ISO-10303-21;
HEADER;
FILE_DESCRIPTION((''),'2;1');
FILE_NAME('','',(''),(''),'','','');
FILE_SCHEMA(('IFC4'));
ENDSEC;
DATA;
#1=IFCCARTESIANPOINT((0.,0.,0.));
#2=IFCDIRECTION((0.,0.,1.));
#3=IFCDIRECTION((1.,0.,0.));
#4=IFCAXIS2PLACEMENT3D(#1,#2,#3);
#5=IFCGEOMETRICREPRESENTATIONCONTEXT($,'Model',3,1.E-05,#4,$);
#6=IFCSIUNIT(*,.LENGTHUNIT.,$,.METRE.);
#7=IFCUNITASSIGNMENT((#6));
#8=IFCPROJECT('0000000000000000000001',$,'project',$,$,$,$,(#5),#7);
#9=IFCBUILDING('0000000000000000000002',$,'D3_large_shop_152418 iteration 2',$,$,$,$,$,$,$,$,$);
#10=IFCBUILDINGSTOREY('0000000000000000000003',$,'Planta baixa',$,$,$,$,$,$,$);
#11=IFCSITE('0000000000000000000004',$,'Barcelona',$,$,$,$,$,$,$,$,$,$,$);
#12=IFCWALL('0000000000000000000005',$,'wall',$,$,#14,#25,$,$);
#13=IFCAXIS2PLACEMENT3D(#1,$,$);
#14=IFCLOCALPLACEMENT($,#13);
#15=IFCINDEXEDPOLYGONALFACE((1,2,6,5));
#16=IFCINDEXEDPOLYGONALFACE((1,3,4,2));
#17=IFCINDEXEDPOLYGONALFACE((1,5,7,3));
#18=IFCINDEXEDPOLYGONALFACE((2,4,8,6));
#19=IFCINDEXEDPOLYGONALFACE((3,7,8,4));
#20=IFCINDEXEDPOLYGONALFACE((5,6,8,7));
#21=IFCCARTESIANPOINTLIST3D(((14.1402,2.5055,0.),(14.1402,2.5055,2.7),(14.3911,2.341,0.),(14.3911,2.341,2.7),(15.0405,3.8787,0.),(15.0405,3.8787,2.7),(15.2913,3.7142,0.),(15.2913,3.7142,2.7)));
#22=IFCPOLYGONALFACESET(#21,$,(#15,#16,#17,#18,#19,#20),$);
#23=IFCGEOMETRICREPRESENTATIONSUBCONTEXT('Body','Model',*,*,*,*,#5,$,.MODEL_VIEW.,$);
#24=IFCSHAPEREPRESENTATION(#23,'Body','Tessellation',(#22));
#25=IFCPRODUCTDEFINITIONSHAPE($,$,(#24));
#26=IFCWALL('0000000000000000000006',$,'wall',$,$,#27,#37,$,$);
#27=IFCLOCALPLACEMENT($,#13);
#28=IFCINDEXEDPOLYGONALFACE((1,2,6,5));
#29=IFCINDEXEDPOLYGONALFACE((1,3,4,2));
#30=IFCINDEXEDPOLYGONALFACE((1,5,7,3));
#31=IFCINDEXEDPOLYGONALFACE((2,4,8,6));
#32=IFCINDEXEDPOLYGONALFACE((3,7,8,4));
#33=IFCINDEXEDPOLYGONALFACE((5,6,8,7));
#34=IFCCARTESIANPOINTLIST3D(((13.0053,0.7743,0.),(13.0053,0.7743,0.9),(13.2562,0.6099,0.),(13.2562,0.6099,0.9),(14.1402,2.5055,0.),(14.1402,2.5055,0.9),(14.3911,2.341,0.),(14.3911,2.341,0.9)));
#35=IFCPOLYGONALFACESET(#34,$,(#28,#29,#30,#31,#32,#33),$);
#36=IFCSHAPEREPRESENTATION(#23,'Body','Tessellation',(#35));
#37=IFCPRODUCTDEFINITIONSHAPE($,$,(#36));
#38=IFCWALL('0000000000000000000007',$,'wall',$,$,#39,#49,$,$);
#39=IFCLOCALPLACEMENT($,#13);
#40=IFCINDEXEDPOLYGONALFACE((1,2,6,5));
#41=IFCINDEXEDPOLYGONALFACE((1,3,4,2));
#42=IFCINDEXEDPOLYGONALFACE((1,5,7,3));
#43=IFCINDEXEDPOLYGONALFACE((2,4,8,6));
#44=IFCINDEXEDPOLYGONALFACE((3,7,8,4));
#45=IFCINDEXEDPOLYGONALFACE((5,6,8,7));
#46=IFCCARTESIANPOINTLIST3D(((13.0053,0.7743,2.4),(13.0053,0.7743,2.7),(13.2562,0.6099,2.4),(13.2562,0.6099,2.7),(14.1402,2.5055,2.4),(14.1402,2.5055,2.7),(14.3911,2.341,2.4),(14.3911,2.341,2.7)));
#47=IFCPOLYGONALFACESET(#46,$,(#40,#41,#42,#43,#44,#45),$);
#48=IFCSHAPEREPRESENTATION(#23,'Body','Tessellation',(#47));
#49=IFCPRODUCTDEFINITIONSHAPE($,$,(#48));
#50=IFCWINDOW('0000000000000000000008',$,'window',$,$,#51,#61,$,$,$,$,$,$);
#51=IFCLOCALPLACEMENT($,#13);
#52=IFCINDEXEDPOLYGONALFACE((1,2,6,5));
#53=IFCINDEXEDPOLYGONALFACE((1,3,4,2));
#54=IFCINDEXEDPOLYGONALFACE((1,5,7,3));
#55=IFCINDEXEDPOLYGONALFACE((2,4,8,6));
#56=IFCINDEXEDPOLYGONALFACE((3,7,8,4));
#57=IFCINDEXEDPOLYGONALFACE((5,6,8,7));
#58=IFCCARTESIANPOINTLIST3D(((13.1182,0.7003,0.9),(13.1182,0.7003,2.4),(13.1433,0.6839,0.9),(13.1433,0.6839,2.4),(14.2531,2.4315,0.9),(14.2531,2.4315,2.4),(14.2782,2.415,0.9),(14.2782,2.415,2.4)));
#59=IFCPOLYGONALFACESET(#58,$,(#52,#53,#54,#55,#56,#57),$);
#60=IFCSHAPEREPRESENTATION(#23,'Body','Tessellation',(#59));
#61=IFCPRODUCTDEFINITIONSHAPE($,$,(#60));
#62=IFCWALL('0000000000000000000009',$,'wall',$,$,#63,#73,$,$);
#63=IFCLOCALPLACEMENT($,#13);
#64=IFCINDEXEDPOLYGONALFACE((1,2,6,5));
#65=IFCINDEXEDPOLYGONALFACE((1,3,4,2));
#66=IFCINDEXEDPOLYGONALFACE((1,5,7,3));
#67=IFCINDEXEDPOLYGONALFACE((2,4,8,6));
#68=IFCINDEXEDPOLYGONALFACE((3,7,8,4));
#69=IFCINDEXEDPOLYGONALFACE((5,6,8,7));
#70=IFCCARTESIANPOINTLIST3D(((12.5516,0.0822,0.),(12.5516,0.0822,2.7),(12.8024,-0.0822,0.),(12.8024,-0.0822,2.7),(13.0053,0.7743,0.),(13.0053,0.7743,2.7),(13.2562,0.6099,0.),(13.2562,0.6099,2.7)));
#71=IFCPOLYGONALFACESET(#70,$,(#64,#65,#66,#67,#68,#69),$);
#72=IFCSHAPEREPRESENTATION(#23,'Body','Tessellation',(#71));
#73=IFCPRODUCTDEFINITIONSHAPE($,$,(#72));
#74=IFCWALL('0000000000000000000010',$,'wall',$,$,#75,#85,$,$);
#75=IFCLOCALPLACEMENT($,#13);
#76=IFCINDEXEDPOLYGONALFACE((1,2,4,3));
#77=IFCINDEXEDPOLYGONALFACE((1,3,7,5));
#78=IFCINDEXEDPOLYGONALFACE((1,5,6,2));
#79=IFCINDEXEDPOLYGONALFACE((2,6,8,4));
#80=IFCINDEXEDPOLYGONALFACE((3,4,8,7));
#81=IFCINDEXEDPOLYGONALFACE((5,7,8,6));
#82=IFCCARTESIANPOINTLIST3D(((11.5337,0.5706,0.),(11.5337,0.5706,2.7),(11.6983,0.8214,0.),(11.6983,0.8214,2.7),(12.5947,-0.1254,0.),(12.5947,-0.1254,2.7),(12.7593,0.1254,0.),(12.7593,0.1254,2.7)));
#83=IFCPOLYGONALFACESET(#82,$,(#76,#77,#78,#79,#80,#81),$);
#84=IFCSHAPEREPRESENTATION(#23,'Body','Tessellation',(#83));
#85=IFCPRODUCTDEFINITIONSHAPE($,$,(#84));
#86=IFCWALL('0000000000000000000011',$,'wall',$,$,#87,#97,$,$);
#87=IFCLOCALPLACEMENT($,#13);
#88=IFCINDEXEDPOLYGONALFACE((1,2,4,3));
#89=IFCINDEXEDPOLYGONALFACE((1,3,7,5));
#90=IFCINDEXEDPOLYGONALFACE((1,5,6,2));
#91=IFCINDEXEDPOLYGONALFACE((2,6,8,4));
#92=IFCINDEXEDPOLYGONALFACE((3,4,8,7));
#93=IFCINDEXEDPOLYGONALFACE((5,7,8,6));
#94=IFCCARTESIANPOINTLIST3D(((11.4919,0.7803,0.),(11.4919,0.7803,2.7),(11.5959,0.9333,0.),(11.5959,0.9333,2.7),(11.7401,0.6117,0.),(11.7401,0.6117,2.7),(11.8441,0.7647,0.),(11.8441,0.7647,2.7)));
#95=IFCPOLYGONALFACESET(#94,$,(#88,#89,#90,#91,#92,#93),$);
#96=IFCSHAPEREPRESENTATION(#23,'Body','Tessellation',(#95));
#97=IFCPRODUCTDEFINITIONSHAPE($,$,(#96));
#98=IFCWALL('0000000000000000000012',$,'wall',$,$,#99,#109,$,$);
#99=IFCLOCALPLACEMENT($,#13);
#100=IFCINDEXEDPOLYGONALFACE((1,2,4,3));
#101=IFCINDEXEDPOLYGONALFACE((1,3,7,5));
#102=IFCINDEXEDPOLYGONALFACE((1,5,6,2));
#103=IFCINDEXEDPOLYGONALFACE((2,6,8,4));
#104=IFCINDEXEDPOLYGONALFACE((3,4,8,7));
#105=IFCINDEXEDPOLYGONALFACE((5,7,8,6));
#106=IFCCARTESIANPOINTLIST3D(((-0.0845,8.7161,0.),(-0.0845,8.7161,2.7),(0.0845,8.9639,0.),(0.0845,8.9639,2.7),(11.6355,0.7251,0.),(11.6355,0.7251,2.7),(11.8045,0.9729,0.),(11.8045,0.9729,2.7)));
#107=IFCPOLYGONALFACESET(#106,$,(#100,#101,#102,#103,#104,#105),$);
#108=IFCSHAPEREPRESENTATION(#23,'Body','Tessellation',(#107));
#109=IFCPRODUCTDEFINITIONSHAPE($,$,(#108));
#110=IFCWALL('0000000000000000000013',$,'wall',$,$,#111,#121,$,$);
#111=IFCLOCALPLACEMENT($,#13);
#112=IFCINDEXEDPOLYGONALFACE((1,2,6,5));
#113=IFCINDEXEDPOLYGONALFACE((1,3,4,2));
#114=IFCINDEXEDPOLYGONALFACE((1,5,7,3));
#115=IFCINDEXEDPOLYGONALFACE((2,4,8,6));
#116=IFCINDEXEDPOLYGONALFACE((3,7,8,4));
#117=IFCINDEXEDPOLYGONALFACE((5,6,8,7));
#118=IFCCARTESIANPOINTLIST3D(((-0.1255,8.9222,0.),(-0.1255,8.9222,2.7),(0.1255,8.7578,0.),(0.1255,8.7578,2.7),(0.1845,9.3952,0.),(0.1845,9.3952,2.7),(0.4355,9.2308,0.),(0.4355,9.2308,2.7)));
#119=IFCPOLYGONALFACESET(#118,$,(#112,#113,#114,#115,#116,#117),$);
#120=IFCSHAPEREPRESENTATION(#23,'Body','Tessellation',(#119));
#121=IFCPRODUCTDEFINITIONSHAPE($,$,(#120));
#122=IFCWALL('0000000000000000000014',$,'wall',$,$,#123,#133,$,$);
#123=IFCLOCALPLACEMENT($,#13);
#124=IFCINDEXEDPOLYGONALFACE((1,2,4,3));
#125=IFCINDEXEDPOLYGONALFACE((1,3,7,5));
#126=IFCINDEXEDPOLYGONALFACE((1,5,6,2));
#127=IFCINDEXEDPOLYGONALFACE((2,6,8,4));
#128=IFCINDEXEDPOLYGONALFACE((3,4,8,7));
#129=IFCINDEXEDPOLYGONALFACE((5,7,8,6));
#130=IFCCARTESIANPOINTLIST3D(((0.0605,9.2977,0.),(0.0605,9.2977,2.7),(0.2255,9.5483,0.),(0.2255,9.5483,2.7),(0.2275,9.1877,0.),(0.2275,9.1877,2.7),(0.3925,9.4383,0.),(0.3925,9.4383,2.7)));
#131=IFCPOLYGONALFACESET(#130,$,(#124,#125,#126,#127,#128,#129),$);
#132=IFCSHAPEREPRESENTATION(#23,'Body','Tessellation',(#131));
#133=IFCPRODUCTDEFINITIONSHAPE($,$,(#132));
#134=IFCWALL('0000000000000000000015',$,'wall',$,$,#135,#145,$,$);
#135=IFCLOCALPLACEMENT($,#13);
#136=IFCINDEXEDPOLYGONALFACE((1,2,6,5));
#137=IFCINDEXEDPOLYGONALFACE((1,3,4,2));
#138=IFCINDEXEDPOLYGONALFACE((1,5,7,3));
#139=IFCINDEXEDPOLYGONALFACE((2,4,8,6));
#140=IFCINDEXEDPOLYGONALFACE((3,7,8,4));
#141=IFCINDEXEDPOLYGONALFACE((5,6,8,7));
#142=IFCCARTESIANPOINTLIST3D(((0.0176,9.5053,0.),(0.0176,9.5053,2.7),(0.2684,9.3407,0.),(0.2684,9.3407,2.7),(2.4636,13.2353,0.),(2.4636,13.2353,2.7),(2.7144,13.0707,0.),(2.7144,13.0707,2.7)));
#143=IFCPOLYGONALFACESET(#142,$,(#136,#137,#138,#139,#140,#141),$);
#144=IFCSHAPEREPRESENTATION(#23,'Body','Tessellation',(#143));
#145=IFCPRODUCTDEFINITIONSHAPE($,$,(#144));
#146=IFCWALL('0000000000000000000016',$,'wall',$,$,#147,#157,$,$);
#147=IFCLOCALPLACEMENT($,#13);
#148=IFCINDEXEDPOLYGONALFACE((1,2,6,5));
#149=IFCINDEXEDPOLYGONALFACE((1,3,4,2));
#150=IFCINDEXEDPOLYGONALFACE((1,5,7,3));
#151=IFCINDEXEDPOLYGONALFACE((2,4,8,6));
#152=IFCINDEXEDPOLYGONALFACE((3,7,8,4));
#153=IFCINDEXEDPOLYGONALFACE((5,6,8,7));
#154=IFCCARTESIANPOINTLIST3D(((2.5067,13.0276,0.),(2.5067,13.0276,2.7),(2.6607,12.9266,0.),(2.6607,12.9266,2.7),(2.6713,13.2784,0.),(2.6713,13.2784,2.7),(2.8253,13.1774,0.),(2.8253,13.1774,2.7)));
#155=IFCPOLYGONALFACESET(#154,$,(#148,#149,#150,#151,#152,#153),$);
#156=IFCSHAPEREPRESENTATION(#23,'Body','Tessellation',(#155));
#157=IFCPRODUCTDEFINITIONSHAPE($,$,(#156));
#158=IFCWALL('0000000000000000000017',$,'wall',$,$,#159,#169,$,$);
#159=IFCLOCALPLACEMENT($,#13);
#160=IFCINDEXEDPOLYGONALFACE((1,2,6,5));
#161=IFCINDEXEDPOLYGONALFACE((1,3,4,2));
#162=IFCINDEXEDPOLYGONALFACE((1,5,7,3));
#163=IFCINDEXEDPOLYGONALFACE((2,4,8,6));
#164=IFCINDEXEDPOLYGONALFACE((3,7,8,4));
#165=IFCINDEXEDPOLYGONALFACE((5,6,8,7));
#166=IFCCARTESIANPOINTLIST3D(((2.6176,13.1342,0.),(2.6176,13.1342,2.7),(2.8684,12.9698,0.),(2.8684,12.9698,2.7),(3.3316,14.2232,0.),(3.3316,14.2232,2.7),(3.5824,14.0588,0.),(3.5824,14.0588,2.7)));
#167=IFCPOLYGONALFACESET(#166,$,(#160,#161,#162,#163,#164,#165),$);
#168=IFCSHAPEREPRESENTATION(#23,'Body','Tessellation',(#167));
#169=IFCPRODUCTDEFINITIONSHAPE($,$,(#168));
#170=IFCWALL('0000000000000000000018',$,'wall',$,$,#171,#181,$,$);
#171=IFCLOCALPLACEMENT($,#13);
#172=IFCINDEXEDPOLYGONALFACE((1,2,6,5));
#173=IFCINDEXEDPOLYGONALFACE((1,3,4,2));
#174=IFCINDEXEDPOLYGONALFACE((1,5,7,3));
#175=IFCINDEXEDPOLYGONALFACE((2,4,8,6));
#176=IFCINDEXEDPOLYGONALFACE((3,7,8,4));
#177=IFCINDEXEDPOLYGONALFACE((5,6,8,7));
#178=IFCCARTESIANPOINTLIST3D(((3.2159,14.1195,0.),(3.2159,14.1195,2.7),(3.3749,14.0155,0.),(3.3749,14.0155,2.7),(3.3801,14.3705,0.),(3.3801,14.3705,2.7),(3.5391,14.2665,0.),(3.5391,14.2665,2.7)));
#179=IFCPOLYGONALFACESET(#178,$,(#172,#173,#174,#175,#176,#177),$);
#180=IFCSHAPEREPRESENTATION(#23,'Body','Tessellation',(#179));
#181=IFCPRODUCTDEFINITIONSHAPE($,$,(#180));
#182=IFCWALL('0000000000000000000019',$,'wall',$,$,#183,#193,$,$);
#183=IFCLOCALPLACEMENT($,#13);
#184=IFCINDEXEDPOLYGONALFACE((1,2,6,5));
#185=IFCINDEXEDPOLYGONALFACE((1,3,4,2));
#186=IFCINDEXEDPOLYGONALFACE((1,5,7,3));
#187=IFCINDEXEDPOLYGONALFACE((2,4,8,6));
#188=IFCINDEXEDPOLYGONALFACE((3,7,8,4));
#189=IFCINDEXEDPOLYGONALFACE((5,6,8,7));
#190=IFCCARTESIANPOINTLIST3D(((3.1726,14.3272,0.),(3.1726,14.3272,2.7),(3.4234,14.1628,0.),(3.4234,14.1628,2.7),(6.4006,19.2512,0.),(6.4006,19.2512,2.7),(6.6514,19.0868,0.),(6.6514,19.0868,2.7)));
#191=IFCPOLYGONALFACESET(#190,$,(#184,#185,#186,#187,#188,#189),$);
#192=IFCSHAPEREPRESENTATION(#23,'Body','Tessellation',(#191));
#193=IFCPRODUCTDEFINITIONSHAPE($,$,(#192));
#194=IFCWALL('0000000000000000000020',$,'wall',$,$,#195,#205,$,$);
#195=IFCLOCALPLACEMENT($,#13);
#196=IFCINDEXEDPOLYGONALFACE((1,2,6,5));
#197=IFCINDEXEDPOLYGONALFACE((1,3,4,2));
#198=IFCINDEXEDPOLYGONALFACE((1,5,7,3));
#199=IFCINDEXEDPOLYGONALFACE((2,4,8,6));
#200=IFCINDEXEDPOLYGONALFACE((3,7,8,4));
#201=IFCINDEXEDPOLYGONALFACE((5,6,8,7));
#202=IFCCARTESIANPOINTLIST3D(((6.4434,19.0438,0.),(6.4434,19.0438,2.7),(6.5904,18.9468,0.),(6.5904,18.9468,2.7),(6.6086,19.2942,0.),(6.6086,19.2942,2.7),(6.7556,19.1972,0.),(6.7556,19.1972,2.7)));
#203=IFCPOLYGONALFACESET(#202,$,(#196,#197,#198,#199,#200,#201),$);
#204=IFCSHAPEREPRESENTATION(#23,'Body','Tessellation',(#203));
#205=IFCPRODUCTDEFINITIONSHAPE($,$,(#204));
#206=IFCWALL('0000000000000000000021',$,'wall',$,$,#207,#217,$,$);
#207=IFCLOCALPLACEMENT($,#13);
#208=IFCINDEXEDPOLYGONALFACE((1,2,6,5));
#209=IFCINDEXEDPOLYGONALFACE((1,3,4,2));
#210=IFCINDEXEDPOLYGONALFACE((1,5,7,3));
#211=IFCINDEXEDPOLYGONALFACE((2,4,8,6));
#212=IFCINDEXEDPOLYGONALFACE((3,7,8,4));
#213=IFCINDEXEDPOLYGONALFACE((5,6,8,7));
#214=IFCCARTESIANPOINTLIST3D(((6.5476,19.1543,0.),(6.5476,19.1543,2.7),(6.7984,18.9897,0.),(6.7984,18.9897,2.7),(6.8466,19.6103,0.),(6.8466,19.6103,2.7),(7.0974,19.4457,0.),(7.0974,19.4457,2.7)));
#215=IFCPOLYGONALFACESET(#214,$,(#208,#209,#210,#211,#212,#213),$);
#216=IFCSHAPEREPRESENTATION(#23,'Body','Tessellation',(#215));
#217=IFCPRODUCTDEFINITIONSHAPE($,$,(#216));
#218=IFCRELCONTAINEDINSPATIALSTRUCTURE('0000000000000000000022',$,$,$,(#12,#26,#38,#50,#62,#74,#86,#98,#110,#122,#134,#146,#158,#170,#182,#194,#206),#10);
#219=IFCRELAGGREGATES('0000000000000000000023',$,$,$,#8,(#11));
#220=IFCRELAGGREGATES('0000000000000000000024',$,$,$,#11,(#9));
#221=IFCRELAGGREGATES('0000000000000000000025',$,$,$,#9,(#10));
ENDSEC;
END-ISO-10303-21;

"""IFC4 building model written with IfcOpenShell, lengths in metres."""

from ifc_helpers import new_model, si_unit, frame, origin, origin_with_axes, place, context, subcontext, project, spatial, polyline, outline, extrude, element, save


model = new_model("IFC4")

# Units and contexts
model_context = context("Model", 3, precision=1e-05, world=origin_with_axes())
body_context = subcontext(model_context, "Body", "Model", "MODEL_VIEW")
ifc_project = project(units=[si_unit("LENGTHUNIT", "METRE")], contexts=[model_context])

# Site, building, storey
site = spatial("IfcSite", under=ifc_project, Name="Barcelona")
building = spatial("IfcBuilding", under=site, Name="D3_large_shop_152418 iteration 2")
storey = spatial("IfcBuildingStorey", under=building, Name="Planta baixa")

# Walls
wall_1_placement = place(None, origin_with_axes())
element("IfcWall", 1, at=wall_1_placement, inside=storey, Name="wall", context=body_context, shape_type="SweptSolid", body=[
    extrude(outline(polyline([(15.2913, 3.7142), (14.3911, 2.341), (14.1402, 2.5055), (15.0405, 3.8787), (15.2913, 3.7142)])), origin(), (0.0, 0.0, 1.0), 2.7),
])
wall_2_placement = place(None, origin_with_axes())
element("IfcWall", 2, at=wall_2_placement, inside=storey, Name="wall", context=body_context, shape_type="SweptSolid", body=[
    extrude(outline(polyline([(14.3911, 2.341), (13.2562, 0.6099), (13.0053, 0.7743), (14.1402, 2.5055), (14.3911, 2.341)])), origin(), (0.0, 0.0, 1.0), 0.9),
])
wall_3_placement = place(None, origin_with_axes())
element("IfcWall", 3, at=wall_3_placement, inside=storey, Name="wall", context=body_context, shape_type="SweptSolid", body=[
    extrude(outline(polyline([(14.3911, 2.341), (13.2562, 0.6099), (13.0053, 0.7743), (14.1402, 2.5055), (14.3911, 2.341)])), frame((0.0, 0.0, 2.4)), (0.0, 0.0, 1.0), 0.3),
])

# Window
window_placement = place(None, origin_with_axes())
element("IfcWindow", 4, at=window_placement, inside=storey, Name="window", context=body_context, shape_type="SweptSolid", body=[
    extrude(outline(polyline([(14.2782, 2.415), (13.1433, 0.6839), (13.1182, 0.7003), (14.2531, 2.4315), (14.2782, 2.415)])), frame((0.0, 0.0, 0.9)), (0.0, 0.0, 1.0), 1.5),
])

# Walls
wall_4_placement = place(None, origin_with_axes())
element("IfcWall", 5, at=wall_4_placement, inside=storey, Name="wall", context=body_context, shape_type="SweptSolid", body=[
    extrude(outline(polyline([(13.2562, 0.6099), (12.8024, -0.0822), (12.5516, 0.0822), (13.0053, 0.7743), (13.2562, 0.6099)])), origin(), (0.0, 0.0, 1.0), 2.7),
])
wall_5_placement = place(None, origin_with_axes())
element("IfcWall", 6, at=wall_5_placement, inside=storey, Name="wall", context=body_context, shape_type="SweptSolid", body=[
    extrude(outline(polyline([(12.5947, -0.1254), (11.5337, 0.5706), (11.6983, 0.8214), (12.7593, 0.1254), (12.5947, -0.1254)])), origin(), (0.0, 0.0, 1.0), 2.7),
])
wall_6_placement = place(None, origin_with_axes())
element("IfcWall", 7, at=wall_6_placement, inside=storey, Name="wall", context=body_context, shape_type="SweptSolid", body=[
    extrude(outline(polyline([(11.4919, 0.7803), (11.5959, 0.9333), (11.8441, 0.7647), (11.7401, 0.6117), (11.4919, 0.7803)])), origin(), (0.0, 0.0, 1.0), 2.7),
])
wall_7_placement = place(None, origin_with_axes())
element("IfcWall", 8, at=wall_7_placement, inside=storey, Name="wall", context=body_context, shape_type="SweptSolid", body=[
    extrude(outline(polyline([(11.6355, 0.7251), (-0.0845, 8.7161), (0.0845, 8.9639), (11.8045, 0.9729), (11.6355, 0.7251)])), origin(), (0.0, 0.0, 1.0), 2.7),
])
wall_8_placement = place(None, origin_with_axes())
element("IfcWall", 9, at=wall_8_placement, inside=storey, Name="wall", context=body_context, shape_type="SweptSolid", body=[
    extrude(outline(polyline([(-0.1255, 8.9222), (0.1845, 9.3952), (0.4355, 9.2308), (0.1255, 8.7578), (-0.1255, 8.9222)])), origin(), (0.0, 0.0, 1.0), 2.7),
])
wall_9_placement = place(None, origin_with_axes())
element("IfcWall", 10, at=wall_9_placement, inside=storey, Name="wall", context=body_context, shape_type="SweptSolid", body=[
    extrude(outline(polyline([(0.2275, 9.1877), (0.0605, 9.2977), (0.2255, 9.5483), (0.3925, 9.4383), (0.2275, 9.1877)])), origin(), (0.0, 0.0, 1.0), 2.7),
])
wall_10_placement = place(None, origin_with_axes())
element("IfcWall", 11, at=wall_10_placement, inside=storey, Name="wall", context=body_context, shape_type="SweptSolid", body=[
    extrude(outline(polyline([(0.0176, 9.5053), (2.4636, 13.2353), (2.7144, 13.0707), (0.2684, 9.3407), (0.0176, 9.5053)])), origin(), (0.0, 0.0, 1.0), 2.7),
])
wall_11_placement = place(None, origin_with_axes())
element("IfcWall", 12, at=wall_11_placement, inside=storey, Name="wall", context=body_context, shape_type="SweptSolid", body=[
    extrude(outline(polyline([(2.6713, 13.2784), (2.8253, 13.1774), (2.6607, 12.9266), (2.5067, 13.0276), (2.6713, 13.2784)])), origin(), (0.0, 0.0, 1.0), 2.7),
])
wall_12_placement = place(None, origin_with_axes())
element("IfcWall", 13, at=wall_12_placement, inside=storey, Name="wall", context=body_context, shape_type="SweptSolid", body=[
    extrude(outline(polyline([(2.6176, 13.1342), (3.3316, 14.2232), (3.5824, 14.0588), (2.8684, 12.9698), (2.6176, 13.1342)])), origin(), (0.0, 0.0, 1.0), 2.7),
])
wall_13_placement = place(None, origin_with_axes())
element("IfcWall", 14, at=wall_13_placement, inside=storey, Name="wall", context=body_context, shape_type="SweptSolid", body=[
    extrude(outline(polyline([(3.3749, 14.0155), (3.2159, 14.1195), (3.3801, 14.3705), (3.5391, 14.2665), (3.3749, 14.0155)])), origin(), (0.0, 0.0, 1.0), 2.7),
])
wall_14_placement = place(None, origin_with_axes())
element("IfcWall", 15, at=wall_14_placement, inside=storey, Name="wall", context=body_context, shape_type="SweptSolid", body=[
    extrude(outline(polyline([(3.1726, 14.3272), (6.4006, 19.2512), (6.6514, 19.0868), (3.4234, 14.1628), (3.1726, 14.3272)])), origin(), (0.0, 0.0, 1.0), 2.7),
])
wall_15_placement = place(None, origin_with_axes())
element("IfcWall", 16, at=wall_15_placement, inside=storey, Name="wall", context=body_context, shape_type="SweptSolid", body=[
    extrude(outline(polyline([(6.6086, 19.2942), (6.7556, 19.1972), (6.5904, 18.9468), (6.4434, 19.0438), (6.6086, 19.2942)])), origin(), (0.0, 0.0, 1.0), 2.7),
])
wall_16_placement = place(None, origin_with_axes())
element("IfcWall", 17, at=wall_16_placement, inside=storey, Name="wall", context=body_context, shape_type="SweptSolid", body=[
    extrude(outline(polyline([(6.5476, 19.1543), (6.8466, 19.6103), (7.0974, 19.4457), (6.7984, 18.9897), (6.5476, 19.1543)])), origin(), (0.0, 0.0, 1.0), 2.7),
])

save(model, "model.ifc")
